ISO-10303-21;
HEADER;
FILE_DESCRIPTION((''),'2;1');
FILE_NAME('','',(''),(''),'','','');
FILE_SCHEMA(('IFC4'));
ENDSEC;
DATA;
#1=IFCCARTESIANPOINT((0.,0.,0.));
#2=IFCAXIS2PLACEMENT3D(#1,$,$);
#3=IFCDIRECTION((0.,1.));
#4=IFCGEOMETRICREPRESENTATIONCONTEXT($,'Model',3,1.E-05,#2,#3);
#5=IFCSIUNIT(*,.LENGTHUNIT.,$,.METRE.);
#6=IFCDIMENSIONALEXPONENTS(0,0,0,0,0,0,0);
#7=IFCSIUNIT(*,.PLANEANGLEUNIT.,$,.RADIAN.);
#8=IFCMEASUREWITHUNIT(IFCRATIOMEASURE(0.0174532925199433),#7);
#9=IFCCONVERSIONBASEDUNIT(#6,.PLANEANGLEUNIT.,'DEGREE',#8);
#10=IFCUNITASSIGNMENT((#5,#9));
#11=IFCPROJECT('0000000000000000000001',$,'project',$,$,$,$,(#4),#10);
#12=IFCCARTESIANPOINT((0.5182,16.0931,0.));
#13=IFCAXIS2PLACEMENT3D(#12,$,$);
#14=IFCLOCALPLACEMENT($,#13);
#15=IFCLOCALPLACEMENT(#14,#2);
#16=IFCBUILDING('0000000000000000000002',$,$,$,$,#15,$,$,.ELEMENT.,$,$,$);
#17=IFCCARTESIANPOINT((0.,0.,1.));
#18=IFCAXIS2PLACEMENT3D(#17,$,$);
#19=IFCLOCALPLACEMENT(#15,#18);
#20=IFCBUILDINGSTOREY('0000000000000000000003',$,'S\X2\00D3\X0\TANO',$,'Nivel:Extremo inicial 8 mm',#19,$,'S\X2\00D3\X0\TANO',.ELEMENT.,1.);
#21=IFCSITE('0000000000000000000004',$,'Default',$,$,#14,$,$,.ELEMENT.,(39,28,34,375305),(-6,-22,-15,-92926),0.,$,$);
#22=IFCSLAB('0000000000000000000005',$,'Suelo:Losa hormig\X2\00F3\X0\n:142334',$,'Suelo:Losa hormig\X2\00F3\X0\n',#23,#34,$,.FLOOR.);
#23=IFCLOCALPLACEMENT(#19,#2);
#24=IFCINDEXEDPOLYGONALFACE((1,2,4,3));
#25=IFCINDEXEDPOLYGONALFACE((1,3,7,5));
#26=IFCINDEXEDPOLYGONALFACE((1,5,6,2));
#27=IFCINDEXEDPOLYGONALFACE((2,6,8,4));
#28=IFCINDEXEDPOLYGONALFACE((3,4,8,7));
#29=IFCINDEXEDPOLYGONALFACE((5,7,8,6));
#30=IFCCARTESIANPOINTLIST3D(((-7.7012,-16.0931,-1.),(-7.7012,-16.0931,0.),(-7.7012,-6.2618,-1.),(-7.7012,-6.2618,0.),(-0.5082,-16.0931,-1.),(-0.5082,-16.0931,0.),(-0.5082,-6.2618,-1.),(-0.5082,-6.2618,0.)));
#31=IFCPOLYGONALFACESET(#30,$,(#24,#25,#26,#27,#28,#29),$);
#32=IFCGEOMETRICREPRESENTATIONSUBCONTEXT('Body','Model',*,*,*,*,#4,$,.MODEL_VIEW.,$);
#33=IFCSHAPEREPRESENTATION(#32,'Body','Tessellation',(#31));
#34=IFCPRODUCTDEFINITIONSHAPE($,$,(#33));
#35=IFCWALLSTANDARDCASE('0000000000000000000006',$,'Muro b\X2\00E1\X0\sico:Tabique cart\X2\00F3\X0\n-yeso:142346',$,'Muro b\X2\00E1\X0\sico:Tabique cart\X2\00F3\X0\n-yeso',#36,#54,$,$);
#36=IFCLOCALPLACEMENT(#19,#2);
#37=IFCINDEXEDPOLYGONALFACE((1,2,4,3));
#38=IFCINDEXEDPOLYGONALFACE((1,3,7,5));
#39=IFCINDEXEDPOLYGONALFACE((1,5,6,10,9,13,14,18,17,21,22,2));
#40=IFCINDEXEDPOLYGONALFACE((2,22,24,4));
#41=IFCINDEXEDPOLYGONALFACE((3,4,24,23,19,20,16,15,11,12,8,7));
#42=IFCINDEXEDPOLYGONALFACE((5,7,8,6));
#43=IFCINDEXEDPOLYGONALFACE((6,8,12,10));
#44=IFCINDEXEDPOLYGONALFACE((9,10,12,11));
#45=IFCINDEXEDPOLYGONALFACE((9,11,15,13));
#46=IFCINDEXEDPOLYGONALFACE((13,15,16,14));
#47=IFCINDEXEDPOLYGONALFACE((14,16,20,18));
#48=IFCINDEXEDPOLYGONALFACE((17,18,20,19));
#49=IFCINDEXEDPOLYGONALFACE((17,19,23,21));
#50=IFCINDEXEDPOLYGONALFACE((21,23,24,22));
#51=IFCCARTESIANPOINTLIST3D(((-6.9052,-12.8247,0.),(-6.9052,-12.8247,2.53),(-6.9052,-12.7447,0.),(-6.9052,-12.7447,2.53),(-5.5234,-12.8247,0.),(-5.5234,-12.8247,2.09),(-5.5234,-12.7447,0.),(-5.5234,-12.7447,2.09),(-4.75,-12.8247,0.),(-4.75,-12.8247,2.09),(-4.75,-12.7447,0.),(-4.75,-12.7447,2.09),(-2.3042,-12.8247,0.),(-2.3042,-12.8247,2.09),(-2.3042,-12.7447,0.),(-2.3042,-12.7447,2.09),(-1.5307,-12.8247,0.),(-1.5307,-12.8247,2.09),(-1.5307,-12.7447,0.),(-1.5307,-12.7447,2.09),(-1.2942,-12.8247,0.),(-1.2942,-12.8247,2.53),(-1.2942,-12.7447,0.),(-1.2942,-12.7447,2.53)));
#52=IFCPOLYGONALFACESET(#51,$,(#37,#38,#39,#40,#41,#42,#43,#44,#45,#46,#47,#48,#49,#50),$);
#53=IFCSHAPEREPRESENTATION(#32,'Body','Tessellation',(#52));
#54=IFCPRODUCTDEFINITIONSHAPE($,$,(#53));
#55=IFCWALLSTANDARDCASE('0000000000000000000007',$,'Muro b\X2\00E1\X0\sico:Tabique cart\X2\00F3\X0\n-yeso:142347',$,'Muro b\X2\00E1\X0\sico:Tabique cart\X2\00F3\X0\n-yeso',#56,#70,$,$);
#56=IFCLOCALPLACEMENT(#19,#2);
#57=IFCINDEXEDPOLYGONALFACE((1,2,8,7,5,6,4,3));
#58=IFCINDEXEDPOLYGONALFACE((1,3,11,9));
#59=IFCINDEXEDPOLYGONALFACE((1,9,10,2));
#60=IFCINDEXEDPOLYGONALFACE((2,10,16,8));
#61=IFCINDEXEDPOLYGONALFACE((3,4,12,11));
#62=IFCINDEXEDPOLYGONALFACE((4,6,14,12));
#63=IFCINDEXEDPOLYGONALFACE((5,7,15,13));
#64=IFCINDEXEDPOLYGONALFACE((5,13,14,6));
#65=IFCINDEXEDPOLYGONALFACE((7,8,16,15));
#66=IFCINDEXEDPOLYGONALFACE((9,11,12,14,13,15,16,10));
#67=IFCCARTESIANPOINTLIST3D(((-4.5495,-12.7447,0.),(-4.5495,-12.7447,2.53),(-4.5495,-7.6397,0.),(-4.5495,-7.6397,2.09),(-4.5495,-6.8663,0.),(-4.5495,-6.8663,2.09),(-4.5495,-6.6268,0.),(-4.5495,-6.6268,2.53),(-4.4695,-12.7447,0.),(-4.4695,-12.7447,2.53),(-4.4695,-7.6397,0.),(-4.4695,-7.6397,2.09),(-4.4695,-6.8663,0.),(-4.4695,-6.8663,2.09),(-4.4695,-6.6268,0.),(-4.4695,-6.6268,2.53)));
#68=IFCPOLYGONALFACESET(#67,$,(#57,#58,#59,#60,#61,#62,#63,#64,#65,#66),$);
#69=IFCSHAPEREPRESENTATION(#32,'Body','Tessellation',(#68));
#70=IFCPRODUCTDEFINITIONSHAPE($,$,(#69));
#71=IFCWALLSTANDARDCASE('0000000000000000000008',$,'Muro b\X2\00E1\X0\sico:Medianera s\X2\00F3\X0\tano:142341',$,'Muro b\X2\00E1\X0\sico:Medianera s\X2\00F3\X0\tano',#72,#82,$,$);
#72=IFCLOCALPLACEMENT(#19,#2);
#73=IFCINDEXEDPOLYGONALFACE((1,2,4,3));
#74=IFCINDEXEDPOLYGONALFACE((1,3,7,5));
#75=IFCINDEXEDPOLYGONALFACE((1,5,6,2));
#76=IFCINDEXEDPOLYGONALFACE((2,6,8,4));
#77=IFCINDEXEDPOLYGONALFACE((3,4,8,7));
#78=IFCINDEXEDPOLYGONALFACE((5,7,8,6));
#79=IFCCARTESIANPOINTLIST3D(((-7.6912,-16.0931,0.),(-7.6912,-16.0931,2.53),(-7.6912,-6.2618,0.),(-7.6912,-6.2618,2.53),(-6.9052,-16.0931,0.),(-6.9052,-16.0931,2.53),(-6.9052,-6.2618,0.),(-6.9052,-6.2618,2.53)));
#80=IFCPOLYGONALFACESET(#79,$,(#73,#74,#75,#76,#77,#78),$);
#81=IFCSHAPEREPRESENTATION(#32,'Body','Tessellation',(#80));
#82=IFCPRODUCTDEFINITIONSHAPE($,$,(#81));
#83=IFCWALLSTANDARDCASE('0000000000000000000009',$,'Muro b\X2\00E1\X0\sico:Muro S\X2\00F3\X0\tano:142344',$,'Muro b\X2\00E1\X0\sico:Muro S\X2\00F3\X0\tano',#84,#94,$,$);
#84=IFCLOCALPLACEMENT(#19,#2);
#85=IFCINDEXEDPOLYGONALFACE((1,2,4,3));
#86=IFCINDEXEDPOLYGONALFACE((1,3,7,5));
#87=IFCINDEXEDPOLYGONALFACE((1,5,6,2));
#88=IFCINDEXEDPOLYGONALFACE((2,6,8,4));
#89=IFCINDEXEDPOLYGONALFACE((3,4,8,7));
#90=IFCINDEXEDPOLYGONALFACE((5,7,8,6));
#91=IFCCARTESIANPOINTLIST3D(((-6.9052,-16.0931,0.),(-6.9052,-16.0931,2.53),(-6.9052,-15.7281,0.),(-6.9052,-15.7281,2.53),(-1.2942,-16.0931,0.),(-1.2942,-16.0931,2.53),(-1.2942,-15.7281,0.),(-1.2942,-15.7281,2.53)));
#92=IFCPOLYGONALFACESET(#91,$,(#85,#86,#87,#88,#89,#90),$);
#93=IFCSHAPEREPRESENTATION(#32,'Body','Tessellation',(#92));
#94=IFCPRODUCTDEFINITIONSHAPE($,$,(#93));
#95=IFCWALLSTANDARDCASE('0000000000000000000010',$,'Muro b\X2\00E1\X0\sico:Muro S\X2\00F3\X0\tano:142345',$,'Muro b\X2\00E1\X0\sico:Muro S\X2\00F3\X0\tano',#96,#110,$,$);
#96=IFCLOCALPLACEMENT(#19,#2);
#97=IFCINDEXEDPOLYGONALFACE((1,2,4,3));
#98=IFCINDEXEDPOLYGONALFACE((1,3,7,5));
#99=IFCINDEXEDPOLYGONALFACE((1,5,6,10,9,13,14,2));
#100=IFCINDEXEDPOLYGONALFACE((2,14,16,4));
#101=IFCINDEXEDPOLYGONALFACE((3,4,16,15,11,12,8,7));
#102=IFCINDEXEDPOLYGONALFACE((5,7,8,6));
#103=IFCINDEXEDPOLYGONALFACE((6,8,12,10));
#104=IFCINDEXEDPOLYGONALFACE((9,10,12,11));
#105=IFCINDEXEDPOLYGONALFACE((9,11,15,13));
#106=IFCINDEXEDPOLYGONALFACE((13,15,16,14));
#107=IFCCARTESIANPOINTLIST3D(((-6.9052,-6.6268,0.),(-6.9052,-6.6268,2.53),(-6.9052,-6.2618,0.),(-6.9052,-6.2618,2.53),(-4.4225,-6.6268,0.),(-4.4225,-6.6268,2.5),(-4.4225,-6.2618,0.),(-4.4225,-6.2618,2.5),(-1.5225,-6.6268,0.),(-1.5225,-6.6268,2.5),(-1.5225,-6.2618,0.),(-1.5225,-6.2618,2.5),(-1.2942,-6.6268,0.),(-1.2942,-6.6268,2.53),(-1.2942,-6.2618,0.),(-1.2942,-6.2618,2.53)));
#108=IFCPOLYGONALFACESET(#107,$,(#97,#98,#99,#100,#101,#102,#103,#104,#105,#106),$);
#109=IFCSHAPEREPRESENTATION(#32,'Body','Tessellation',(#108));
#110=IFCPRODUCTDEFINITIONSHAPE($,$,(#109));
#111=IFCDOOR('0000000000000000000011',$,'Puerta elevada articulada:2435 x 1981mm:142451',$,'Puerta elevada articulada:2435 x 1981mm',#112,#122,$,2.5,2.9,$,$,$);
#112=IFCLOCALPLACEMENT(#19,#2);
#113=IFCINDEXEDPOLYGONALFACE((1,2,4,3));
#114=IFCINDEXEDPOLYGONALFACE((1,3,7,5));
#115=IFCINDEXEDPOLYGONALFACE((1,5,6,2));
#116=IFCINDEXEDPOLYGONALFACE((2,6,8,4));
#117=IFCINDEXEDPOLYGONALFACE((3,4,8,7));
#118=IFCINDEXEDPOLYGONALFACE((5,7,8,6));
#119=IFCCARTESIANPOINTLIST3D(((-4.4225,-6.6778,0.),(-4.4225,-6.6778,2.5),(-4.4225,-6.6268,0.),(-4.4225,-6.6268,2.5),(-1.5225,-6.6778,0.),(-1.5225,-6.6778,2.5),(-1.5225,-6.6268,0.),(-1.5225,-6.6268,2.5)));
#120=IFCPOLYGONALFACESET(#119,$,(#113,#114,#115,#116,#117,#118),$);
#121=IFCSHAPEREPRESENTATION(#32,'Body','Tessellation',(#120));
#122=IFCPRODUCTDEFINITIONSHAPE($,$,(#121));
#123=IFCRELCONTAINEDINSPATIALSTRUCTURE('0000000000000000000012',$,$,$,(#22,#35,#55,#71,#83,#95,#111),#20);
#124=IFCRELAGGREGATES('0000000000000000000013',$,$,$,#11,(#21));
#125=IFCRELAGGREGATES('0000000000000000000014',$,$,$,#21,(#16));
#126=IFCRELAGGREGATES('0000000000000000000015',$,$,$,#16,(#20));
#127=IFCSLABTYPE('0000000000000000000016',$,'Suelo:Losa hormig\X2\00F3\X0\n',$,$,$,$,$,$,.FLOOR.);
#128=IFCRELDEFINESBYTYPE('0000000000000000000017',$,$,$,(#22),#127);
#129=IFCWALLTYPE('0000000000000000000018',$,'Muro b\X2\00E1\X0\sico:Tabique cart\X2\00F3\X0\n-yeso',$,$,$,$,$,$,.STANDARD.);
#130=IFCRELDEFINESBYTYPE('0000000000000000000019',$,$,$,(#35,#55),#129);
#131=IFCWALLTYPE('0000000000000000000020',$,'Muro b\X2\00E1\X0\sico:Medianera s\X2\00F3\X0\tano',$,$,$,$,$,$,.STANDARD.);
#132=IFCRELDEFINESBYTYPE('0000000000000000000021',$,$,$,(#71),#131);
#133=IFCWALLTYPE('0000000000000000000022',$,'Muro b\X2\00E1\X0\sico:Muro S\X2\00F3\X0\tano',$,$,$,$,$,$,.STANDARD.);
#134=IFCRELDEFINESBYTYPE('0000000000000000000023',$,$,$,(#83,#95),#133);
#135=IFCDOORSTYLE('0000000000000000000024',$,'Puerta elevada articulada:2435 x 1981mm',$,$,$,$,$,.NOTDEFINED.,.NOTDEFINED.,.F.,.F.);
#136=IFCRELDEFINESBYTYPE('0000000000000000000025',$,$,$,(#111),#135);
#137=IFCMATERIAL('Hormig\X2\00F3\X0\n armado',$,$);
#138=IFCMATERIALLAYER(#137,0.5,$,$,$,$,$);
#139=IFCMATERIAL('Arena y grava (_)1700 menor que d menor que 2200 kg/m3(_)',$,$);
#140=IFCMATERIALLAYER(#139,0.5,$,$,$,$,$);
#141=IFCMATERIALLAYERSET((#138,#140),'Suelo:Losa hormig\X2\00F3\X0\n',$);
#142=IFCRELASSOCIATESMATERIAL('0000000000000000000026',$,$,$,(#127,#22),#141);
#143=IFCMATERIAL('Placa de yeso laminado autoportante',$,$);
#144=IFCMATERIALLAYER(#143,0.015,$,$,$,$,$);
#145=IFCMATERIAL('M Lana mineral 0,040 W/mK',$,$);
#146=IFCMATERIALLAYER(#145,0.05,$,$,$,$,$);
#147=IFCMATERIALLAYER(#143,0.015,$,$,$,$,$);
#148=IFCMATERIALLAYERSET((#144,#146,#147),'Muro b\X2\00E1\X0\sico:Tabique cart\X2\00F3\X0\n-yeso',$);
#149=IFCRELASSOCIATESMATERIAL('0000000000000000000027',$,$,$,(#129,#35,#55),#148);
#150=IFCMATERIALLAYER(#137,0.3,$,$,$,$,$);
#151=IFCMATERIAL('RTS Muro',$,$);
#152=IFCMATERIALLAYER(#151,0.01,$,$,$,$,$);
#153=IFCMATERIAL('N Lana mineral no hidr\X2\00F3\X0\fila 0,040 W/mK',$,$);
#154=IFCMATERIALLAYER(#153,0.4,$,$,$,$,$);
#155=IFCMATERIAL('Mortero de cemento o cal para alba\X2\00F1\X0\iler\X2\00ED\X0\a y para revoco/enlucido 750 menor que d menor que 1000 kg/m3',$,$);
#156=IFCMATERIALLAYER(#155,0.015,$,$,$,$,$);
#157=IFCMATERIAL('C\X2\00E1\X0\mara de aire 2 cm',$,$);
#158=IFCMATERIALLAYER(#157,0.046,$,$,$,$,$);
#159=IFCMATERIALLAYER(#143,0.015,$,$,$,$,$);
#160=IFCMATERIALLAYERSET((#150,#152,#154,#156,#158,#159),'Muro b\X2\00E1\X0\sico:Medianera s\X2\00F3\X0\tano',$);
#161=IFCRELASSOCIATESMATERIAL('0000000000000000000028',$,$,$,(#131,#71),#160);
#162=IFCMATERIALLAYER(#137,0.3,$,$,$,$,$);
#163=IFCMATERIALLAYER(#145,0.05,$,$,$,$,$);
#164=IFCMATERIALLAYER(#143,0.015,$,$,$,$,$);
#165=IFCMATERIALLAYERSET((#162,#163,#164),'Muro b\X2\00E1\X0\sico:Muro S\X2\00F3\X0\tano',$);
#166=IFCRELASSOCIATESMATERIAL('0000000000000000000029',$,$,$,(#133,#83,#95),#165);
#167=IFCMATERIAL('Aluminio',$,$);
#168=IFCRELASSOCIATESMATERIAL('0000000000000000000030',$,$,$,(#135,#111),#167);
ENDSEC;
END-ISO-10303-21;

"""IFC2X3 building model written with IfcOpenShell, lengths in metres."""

from ifc_helpers import new_model, entity, si_unit, converted_unit, direction, frame, frame_2d, origin, origin_2d_with_axis, place, context, subcontext, project, spatial, polyline, rectangle, extrude, clip, bounded_halfspace, source, transform, mapped, material, layer, layer_set, layer_usage, type_object, type_shapes, element, fill, save


model = new_model("IFC2X3")

# Units and contexts
model_context = context("Model", 3, precision=1e-05, world=origin(), true_north=direction((0.0, 1.0)))
body_context = subcontext(model_context, "Body", "Model", "MODEL_VIEW")
ifc_project = project(units=[si_unit("LENGTHUNIT", "METRE"), converted_unit("PLANEANGLEUNIT", "DEGREE", entity("IfcRatioMeasure", 0.0174532925199433), si_unit("PLANEANGLEUNIT", "RADIAN"), dimensions=[0, 0, 0, 0, 0, 0, 0])], contexts=[model_context])

# Site, building, storey
site_placement = place(None, frame((0.5182, 16.0931, 0.0)))
site = spatial("IfcSite", under=ifc_project, at=site_placement, Name="Default", CompositionType="ELEMENT", RefLatitude=(39, 28, 34, 375305), RefLongitude=(-6, -22, -15, -92926), RefElevation=0.0)
building_placement = place(site_placement, origin())
building = spatial("IfcBuilding", under=site, at=building_placement, CompositionType="ELEMENT")
storey_placement = place(building_placement, frame((0.0, 0.0, 1.0)))
storey = spatial("IfcBuildingStorey", under=building, at=storey_placement, Name="SÓTANO", ObjectType="Nivel:Extremo inicial 8 mm", LongName="SÓTANO", CompositionType="ELEMENT", Elevation=1.0)

# Slab
ifc_material_1 = material(Name="Hormigón armado")
ifc_layer_1 = layer(ifc_material_1, 0.5)
ifc_material_2 = material(Name="Arena y grava (_)1700 menor que d menor que 2200 kg/m3(_)")
ifc_layer_2 = layer(ifc_material_2, 0.5)
ifc_layer_set_1 = layer_set([ifc_layer_1, ifc_layer_2], Name="Suelo:Losa hormigón")
ifc_layer_usage_1 = layer_usage(ifc_layer_set_1, "AXIS3", "POSITIVE", 0.0)
slab_type = type_object("IfcSlabType", Name="Suelo:Losa hormigón", PredefinedType="FLOOR", material=ifc_layer_set_1)
slab_placement = place(storey_placement, origin())
element("IfcSlab", 1, at=slab_placement, inside=storey, type_object=slab_type, material=ifc_layer_usage_1, Name="Suelo:Losa hormigón:142334", ObjectType="Suelo:Losa hormigón", PredefinedType="FLOOR", context=body_context, shape_type="SweptSolid", body=[
    extrude(rectangle(XDim=9.8314, YDim=7.1931, at=origin_2d_with_axis()), frame((-4.1047, -11.1775, 0.0), z_axis=(0.0, 0.0, -1.0), x_axis=(0.0, 1.0, 0.0)), (0.0, 0.0, 1.0), 1.0),
])

# Wall, openings
ifc_material_3 = material(Name="Placa de yeso laminado autoportante")
ifc_layer_3 = layer(ifc_material_3, 0.015)
ifc_material_4 = material(Name="M Lana mineral 0,040 W/mK")
ifc_layer_4 = layer(ifc_material_4, 0.05)
ifc_layer_5 = layer(ifc_material_3, 0.015)
ifc_layer_set_2 = layer_set([ifc_layer_3, ifc_layer_4, ifc_layer_5], Name="Muro básico:Tabique cartón-yeso")
ifc_layer_usage_2 = layer_usage(ifc_layer_set_2, "AXIS2", "POSITIVE", -0.04)
wall_type_1 = type_object("IfcWallType", Name="Muro básico:Tabique cartón-yeso", PredefinedType="STANDARD", material=ifc_layer_set_2)
wall_1_placement = place(storey_placement, frame((-6.9052, -12.7847, 0.0)))
wall_1 = element("IfcWallStandardCase", 2, at=wall_1_placement, inside=storey, type_object=wall_type_1, material=ifc_layer_usage_2, Name="Muro básico:Tabique cartón-yeso:142346", ObjectType="Muro básico:Tabique cartón-yeso", context=body_context, shape_type="Clipping", body=[
    clip(extrude(rectangle(XDim=5.6111, YDim=0.08, at=frame_2d((2.8055, 0.0), x_axis=(-1.0, 0.0))), origin(), (0.0, 0.0, 1.0), 2.53), bounded_halfspace(frame((0.0, -0.04, 2.53), z_axis=(0.0, 0.0, -1.0), x_axis=(0.0, 1.0, 0.0)), True, frame((0.0, -0.04, 2.53)), polyline([(0.0, 0.0), (5.6111, 0.0), (5.6111, 0.08), (2.4358, 0.08), (2.3558, 0.08), (0.0, 0.08), (0.0, 0.0)]))),
])
opening_1_placement = place(wall_1_placement, frame((6.9052, 12.7847, 0.0)))
element("IfcOpeningElement", 3, at=opening_1_placement, cuts=wall_1, ObjectType="Opening", context=body_context, shape_type="SweptSolid", body=[
    extrude(rectangle(XDim=2.09, YDim=0.7734, at=frame_2d((0.0, 0.0), x_axis=(1.0, 0.0))), frame((-5.1367, -12.9747, 1.045), z_axis=(0.0, 1.0, 0.0), x_axis=(0.0, 0.0, -1.0)), (0.0, 0.0, 1.0), 0.23),
])
opening_2_placement = place(wall_1_placement, frame((6.9052, 12.7847, 0.0)))
element("IfcOpeningElement", 4, at=opening_2_placement, cuts=wall_1, ObjectType="Opening", context=body_context, shape_type="SweptSolid", body=[
    extrude(rectangle(XDim=2.09, YDim=0.7734, at=frame_2d((0.0, 0.0), x_axis=(1.0, 0.0))), frame((-1.9175, -12.9747, 1.045), z_axis=(0.0, 1.0, 0.0), x_axis=(0.0, 0.0, -1.0)), (0.0, 0.0, 1.0), 0.23),
])

# Wall, opening
ifc_layer_usage_3 = layer_usage(ifc_layer_set_2, "AXIS2", "POSITIVE", -0.04)
wall_2_placement = place(storey_placement, frame((-4.5095, -12.7447, 0.0), z_axis=(0.0, 0.0, 1.0), x_axis=(0.0, 1.0, 0.0)))
wall_2 = element("IfcWallStandardCase", 5, at=wall_2_placement, inside=storey, type_object=wall_type_1, material=ifc_layer_usage_3, Name="Muro básico:Tabique cartón-yeso:142347", ObjectType="Muro básico:Tabique cartón-yeso", context=body_context, shape_type="Clipping", body=[
    clip(extrude(rectangle(XDim=6.1179, YDim=0.08, at=frame_2d((3.059, 0.0), x_axis=(-1.0, 0.0))), origin(), (0.0, 0.0, 1.0), 2.53), bounded_halfspace(frame((0.0, -0.04, 2.53), z_axis=(0.0, 0.0, -1.0), x_axis=(1.0, 0.0, 0.0)), True, frame((0.0, -0.04, 2.53)), polyline([(0.0, 0.0), (6.1179, 0.0), (6.1179, 0.08), (0.0, 0.08), (0.0, 0.0)]))),
])
opening_3_placement = place(wall_2_placement, frame((12.7447, -4.5095, 0.0), z_axis=(0.0, 0.0, 1.0), x_axis=(0.0, -1.0, 0.0)))
element("IfcOpeningElement", 6, at=opening_3_placement, cuts=wall_2, ObjectType="Opening", context=body_context, shape_type="SweptSolid", body=[
    extrude(rectangle(XDim=2.09, YDim=0.7734, at=frame_2d((0.0, 0.0), x_axis=(1.0, 0.0))), frame((-4.3195, -7.253, 1.045), z_axis=(-1.0, 0.0, 0.0), x_axis=(0.0, 0.0, -1.0)), (0.0, 0.0, 1.0), 0.23),
])

# Walls
ifc_layer_6 = layer(ifc_material_1, 0.3)
ifc_material_5 = material(Name="RTS Muro")
ifc_layer_7 = layer(ifc_material_5, 0.01)
ifc_material_6 = material(Name="N Lana mineral no hidrófila 0,040 W/mK")
ifc_layer_8 = layer(ifc_material_6, 0.4)
ifc_material_7 = material(Name="Mortero de cemento o cal para albañilería y para revoco/enlucido 750 menor que d menor que 1000 kg/m3")
ifc_layer_9 = layer(ifc_material_7, 0.015)
ifc_material_8 = material(Name="Cámara de aire 2 cm")
ifc_layer_10 = layer(ifc_material_8, 0.046)
ifc_layer_11 = layer(ifc_material_3, 0.015)
ifc_layer_set_3 = layer_set([ifc_layer_6, ifc_layer_7, ifc_layer_8, ifc_layer_9, ifc_layer_10, ifc_layer_11], Name="Muro básico:Medianera sótano")
ifc_layer_usage_4 = layer_usage(ifc_layer_set_3, "AXIS2", "POSITIVE", -0.393)
wall_type_2 = type_object("IfcWallType", Name="Muro básico:Medianera sótano", PredefinedType="STANDARD", material=ifc_layer_set_3)
wall_3_placement = place(storey_placement, frame((-7.2982, -6.2618, 0.0), z_axis=(0.0, 0.0, 1.0), x_axis=(0.0, -1.0, 0.0)))
element("IfcWallStandardCase", 7, at=wall_3_placement, inside=storey, type_object=wall_type_2, material=ifc_layer_usage_4, Name="Muro básico:Medianera sótano:142341", ObjectType="Muro básico:Medianera sótano", context=body_context, shape_type="Clipping", body=[
    clip(extrude(rectangle(XDim=9.8314, YDim=0.786, at=frame_2d((4.9157, 0.0), x_axis=(-1.0, 0.0))), origin(), (0.0, 0.0, 1.0), 2.53), bounded_halfspace(frame((0.0, -0.393, 2.53), z_axis=(0.0, 0.0, -1.0), x_axis=(-1.0, 0.0, 0.0)), True, frame((0.0, -0.393, 2.53)), polyline([(0.0, 0.0), (9.8314, 0.0), (9.8314, 0.786), (9.4664, 0.786), (9.4116, 0.786), (6.5629, 0.786), (6.4829, 0.786), (0.365, 0.786), (0.0, 0.786), (0.0, 0.0)]))),
])
ifc_layer_12 = layer(ifc_material_1, 0.3)
ifc_layer_13 = layer(ifc_material_4, 0.05)
ifc_layer_14 = layer(ifc_material_3, 0.015)
ifc_layer_set_4 = layer_set([ifc_layer_12, ifc_layer_13, ifc_layer_14], Name="Muro básico:Muro Sótano")
ifc_layer_usage_5 = layer_usage(ifc_layer_set_4, "AXIS2", "POSITIVE", -0.1825)
wall_type_3 = type_object("IfcWallType", Name="Muro básico:Muro Sótano", PredefinedType="STANDARD", material=ifc_layer_set_4)
wall_4_placement = place(storey_placement, frame((-6.9052, -15.9106, 0.0)))
element("IfcWallStandardCase", 8, at=wall_4_placement, inside=storey, type_object=wall_type_3, material=ifc_layer_usage_5, Name="Muro básico:Muro Sótano:142344", ObjectType="Muro básico:Muro Sótano", context=body_context, shape_type="Clipping", body=[
    clip(extrude(rectangle(XDim=5.6111, YDim=0.365, at=frame_2d((2.8055, 0.0), x_axis=(-1.0, 0.0))), origin(), (0.0, 0.0, 1.0), 2.53), bounded_halfspace(frame((0.0, -0.1825, 2.53), z_axis=(0.0, 0.0, -1.0), x_axis=(0.0, 1.0, 0.0)), True, frame((0.0, -0.1825, 2.53)), polyline([(0.0, 0.0), (5.6111, 0.0), (5.6111, 0.365), (5.5461, 0.365), (0.0461, 0.365), (0.0, 0.365), (0.0, 0.0)]))),
])

# Wall, opening, door
ifc_layer_usage_6 = layer_usage(ifc_layer_set_4, "AXIS2", "NEGATIVE", 0.1825)
wall_5_placement = place(storey_placement, frame((-6.9052, -6.4443, 0.0)))
wall_5 = element("IfcWallStandardCase", 9, at=wall_5_placement, inside=storey, type_object=wall_type_3, material=ifc_layer_usage_6, Name="Muro básico:Muro Sótano:142345", ObjectType="Muro básico:Muro Sótano", context=body_context, shape_type="Clipping", body=[
    clip(extrude(rectangle(XDim=5.6111, YDim=0.365, at=frame_2d((2.8055, 0.0), x_axis=(-1.0, 0.0))), origin(), (0.0, 0.0, 1.0), 2.53), bounded_halfspace(frame((0.0, -0.1825, 2.53), z_axis=(0.0, 0.0, -1.0), x_axis=(0.0, 1.0, 0.0)), True, frame((0.0, -0.1825, 2.53)), polyline([(0.0, 0.0), (0.0358, 0.0), (2.3558, 0.0), (2.4358, 0.0), (5.4908, 0.0), (5.6111, 0.0), (5.6111, 0.365), (0.0, 0.365), (0.0, 0.13), (0.0, 0.0)]))),
])
opening_4_placement = place(wall_5_placement, frame((5.3828, 0.1825, 0.0)))
opening_4 = element("IfcOpeningElement", 10, at=opening_4_placement, cuts=wall_5, ObjectType="Opening", context=body_context, shape_type="SweptSolid", body=[
    extrude(rectangle(XDim=2.5, YDim=2.9, at=frame_2d((1.25, 1.45), x_axis=(1.0, 0.0))), frame((0.0, 0.0, 0.0), z_axis=(0.0, -1.0, 0.0), x_axis=(0.0, 0.0, 1.0)), (0.0, 0.0, 1.0), 0.365),
])
ifc_material_9 = material(Name="Aluminio")
door_style = type_object("IfcDoorStyle", Name="Puerta elevada articulada:2435 x 1981mm", ConstructionType="NOTDEFINED", OperationType="NOTDEFINED", ParameterTakesPrecedence=False, Sizeable=False, material=ifc_material_9)
shared_shape = source(origin(), body_context, "Body", "SweptSolid", [
    extrude(rectangle(XDim=2.9, YDim=0.051, at=origin_2d_with_axis()), frame((1.45, -0.0255, 0.0), z_axis=(0.0, 0.0, 1.0), x_axis=(-1.0, 0.0, 0.0)), (0.0, 0.0, 1.0), 2.5),
])
type_shapes(door_style, [shared_shape])
door_placement = place(opening_4_placement, frame((-2.9, -0.365, 0.0)))
door = element("IfcDoor", 11, at=door_placement, inside=storey, type_object=door_style, material=ifc_material_9, Name="Puerta elevada articulada:2435 x 1981mm:142451", ObjectType="Puerta elevada articulada:2435 x 1981mm", OverallHeight=2.5, OverallWidth=2.9, context=body_context, shape_type="MappedRepresentation", body=[
    mapped(shared_shape, transform((0.0, 0.0, 0.0), scale=1.0)),
])
fill(opening_4, door)

save(model, "model.ifc")
